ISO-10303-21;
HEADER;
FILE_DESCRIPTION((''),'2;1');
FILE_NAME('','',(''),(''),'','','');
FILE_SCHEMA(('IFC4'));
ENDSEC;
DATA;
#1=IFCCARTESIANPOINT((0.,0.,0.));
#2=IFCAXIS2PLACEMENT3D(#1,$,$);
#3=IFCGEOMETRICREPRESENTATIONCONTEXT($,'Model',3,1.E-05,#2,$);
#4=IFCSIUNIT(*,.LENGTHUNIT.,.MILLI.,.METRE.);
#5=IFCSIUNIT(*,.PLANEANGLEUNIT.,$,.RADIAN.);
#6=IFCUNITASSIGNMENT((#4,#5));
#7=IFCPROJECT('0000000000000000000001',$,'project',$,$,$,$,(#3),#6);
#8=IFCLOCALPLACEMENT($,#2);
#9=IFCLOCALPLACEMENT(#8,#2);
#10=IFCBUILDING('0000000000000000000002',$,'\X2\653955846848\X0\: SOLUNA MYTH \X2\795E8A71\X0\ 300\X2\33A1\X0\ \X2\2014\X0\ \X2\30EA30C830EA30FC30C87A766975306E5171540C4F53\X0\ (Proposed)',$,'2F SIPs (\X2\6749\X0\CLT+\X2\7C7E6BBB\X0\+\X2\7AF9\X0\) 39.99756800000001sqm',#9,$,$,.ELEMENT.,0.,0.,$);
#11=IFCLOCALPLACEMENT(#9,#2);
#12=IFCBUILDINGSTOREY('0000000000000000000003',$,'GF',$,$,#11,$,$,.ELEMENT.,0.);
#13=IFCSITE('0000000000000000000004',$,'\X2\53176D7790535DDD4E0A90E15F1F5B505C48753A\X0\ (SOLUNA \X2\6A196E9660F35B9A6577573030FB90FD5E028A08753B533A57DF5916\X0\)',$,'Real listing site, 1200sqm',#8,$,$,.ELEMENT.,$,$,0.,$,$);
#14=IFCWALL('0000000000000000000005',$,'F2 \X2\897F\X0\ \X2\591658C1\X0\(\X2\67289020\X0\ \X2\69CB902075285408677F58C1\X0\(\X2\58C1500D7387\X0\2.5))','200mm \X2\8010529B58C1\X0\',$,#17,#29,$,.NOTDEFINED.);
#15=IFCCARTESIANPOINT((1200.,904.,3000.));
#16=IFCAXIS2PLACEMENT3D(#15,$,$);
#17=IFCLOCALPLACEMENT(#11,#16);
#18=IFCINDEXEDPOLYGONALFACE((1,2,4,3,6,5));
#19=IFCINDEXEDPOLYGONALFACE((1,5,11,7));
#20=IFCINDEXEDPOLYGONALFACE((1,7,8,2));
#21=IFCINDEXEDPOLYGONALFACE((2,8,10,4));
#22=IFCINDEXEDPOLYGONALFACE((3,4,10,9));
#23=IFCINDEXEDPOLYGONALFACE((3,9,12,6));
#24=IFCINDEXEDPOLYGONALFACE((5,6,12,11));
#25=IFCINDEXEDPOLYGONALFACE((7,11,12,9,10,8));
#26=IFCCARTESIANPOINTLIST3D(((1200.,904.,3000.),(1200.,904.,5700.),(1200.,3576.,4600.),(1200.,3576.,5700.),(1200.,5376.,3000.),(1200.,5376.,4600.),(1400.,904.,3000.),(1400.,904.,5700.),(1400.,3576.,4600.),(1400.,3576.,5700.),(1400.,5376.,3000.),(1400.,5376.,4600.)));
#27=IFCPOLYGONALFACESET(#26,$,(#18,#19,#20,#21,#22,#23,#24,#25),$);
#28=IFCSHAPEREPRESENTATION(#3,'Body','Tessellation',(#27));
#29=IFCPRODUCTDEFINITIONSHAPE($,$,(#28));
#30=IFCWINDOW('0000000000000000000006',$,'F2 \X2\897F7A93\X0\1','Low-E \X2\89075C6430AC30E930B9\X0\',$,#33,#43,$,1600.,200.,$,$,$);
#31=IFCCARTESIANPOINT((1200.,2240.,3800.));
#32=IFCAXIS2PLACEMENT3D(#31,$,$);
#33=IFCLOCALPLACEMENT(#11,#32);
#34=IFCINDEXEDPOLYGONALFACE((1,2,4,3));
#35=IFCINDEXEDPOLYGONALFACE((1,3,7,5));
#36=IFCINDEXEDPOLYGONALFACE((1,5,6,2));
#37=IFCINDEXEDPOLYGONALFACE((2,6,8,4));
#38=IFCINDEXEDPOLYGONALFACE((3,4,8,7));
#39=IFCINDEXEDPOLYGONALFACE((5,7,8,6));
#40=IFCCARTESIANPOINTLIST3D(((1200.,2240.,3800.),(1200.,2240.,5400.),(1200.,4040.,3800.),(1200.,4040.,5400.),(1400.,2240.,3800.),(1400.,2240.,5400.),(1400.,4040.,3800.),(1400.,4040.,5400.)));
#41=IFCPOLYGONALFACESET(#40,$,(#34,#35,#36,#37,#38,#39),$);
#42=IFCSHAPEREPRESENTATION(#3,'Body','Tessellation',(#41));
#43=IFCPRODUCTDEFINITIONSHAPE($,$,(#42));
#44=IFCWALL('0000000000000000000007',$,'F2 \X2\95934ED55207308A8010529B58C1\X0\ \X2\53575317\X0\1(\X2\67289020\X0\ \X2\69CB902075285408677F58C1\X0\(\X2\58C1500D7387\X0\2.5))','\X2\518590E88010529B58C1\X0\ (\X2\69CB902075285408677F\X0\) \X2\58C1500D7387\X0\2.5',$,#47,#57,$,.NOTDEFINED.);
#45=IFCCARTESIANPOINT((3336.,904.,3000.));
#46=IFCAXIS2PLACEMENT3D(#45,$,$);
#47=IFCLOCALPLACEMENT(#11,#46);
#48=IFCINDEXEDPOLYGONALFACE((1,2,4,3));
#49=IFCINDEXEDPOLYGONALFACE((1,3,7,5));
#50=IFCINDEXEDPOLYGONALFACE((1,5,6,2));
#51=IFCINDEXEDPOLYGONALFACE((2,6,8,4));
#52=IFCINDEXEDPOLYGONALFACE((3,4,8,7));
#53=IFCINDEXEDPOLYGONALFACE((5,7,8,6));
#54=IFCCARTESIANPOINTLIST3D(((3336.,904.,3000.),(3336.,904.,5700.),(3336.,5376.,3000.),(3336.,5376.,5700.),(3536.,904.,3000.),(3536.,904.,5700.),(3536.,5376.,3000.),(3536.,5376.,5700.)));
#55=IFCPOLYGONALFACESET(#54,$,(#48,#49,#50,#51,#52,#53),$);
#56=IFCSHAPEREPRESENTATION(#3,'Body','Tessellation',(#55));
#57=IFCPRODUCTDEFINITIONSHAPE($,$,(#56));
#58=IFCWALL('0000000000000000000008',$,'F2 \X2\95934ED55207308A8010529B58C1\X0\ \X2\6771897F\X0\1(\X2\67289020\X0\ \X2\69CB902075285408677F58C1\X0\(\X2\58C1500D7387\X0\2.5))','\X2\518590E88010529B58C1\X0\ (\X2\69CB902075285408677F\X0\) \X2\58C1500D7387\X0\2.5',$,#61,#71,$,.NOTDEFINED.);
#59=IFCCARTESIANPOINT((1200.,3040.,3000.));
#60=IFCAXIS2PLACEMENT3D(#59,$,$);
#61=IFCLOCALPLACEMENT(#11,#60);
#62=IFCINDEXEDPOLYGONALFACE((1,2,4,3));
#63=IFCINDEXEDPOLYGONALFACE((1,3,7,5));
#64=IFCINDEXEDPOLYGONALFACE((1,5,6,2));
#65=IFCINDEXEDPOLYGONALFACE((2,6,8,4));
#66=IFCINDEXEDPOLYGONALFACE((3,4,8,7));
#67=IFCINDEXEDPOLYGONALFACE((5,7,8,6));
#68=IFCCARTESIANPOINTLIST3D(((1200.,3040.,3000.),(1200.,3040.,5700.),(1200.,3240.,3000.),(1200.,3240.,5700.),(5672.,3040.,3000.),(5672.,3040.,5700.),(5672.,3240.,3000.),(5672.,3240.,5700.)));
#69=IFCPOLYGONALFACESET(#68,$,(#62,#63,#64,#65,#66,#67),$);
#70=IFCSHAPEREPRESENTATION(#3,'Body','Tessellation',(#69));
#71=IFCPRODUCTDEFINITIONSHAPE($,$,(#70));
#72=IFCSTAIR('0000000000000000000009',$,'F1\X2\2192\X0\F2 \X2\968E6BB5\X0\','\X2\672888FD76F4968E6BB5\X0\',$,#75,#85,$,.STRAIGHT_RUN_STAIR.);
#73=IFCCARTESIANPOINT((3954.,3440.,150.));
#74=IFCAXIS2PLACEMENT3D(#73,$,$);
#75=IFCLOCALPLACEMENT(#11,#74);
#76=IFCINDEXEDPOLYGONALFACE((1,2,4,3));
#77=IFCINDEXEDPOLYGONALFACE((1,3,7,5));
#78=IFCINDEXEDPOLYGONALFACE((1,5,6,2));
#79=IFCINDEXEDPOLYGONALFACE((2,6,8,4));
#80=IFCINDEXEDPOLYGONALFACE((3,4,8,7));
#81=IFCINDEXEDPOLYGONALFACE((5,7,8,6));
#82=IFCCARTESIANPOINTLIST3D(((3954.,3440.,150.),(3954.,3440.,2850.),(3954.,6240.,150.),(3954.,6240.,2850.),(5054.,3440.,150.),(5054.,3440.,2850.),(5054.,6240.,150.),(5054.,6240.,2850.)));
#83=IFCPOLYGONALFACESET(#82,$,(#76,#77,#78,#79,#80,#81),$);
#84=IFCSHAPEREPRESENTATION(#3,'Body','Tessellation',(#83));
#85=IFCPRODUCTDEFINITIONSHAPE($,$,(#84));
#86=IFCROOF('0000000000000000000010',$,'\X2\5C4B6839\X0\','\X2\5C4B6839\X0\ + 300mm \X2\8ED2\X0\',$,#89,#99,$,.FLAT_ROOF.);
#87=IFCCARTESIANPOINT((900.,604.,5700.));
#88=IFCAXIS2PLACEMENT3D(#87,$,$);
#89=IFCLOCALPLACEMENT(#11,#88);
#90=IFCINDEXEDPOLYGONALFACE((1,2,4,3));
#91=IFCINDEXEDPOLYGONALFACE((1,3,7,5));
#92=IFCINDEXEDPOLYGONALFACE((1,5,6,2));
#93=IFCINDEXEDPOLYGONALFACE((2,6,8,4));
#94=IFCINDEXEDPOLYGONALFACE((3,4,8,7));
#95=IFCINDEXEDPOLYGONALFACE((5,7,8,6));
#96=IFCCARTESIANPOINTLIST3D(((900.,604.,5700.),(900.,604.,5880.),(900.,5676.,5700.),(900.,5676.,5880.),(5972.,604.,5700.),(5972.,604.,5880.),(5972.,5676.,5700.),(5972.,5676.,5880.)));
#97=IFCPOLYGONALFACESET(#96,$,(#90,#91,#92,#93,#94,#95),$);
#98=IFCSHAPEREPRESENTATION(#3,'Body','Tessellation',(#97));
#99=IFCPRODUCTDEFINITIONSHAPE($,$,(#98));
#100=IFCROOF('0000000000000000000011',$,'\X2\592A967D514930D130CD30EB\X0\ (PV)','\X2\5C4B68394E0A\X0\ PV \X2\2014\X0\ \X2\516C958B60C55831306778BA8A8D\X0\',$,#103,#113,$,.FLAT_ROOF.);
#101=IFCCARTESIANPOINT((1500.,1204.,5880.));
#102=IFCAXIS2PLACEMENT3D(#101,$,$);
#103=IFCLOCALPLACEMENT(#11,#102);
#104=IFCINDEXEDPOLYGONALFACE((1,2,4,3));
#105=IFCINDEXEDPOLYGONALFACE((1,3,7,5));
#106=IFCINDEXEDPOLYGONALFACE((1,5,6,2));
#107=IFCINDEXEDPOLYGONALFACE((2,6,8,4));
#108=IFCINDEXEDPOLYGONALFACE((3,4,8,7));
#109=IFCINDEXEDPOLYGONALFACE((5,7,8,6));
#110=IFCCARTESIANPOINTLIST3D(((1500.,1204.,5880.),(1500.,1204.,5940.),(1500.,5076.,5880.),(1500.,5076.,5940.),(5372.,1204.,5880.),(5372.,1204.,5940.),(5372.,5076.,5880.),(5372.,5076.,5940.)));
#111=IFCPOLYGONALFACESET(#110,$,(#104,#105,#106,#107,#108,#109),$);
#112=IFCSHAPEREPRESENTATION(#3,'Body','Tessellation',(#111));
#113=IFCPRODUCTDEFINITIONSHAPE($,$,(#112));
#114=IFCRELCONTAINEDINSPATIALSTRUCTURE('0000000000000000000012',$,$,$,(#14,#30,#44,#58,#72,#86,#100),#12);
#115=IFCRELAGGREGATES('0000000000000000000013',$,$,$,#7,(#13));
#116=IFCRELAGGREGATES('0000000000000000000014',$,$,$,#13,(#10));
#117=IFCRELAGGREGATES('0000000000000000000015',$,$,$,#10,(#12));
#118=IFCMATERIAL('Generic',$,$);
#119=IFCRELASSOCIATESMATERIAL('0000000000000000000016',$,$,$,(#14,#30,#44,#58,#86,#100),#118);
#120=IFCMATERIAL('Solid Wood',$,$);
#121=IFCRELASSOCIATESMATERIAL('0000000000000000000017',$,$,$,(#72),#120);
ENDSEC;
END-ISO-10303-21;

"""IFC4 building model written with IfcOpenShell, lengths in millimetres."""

from ifc_helpers import new_model, si_unit, frame, frame_2d, origin, place, context, project, spatial, rectangle, extrude, material, element, fill, save


model = new_model("IFC4")

# Units and contexts
model_context = context("Model", 3, precision=1e-05, world=origin())
ifc_project = project(units=[si_unit("LENGTHUNIT", "METRE", prefix="MILLI"), si_unit("PLANEANGLEUNIT", "RADIAN")], contexts=[model_context])

# Site, building, storey
site_placement = place(None, origin())
site = spatial("IfcSite", under=ifc_project, at=site_placement, Name="北海道川上郡弟子屈町 (SOLUNA 標準想定敷地・都市計画区域外)", ObjectType="Real listing site, 1200sqm", CompositionType="ELEMENT", RefElevation=0.0)
building_placement = place(site_placement, origin())
building = spatial("IfcBuilding", under=site, at=building_placement, Name="改善案: SOLUNA MYTH 神話 300㎡ — リトリート究極の共同体 (Proposed)", ObjectType="2F SIPs (杉CLT+籾殻+竹) 39.99756800000001sqm", CompositionType="ELEMENT", ElevationOfRefHeight=0.0, ElevationOfTerrain=0.0)
storey_placement = place(building_placement, origin())
storey = spatial("IfcBuildingStorey", under=building, at=storey_placement, Name="GF", CompositionType="ELEMENT", Elevation=0.0)

# Shared definitions
ifc_material_1 = material(Name="Generic")

# Shared definitions
ifc_material_2 = material(Name="Solid Wood")

# Wall, opening, window
wall_1_placement = place(storey_placement, frame((1200.0, 904.0, 3000.0)))
wall_1 = element("IfcWall", 1, at=wall_1_placement, inside=storey, material=ifc_material_1, Name="F2 西 外壁(木造 構造用合板壁(壁倍率2.5))", Description="200mm 耐力壁", PredefinedType="NOTDEFINED", context=model_context, shape_type="SweptSolid", body=[
    extrude(rectangle(XDim=200.0, YDim=4472.0, at=frame_2d((100.0, 2236.0))), frame((1200.0, 904.0, 3000.0)), (0.0, 0.0, 1.0), 2700.0),
])
opening_1_placement = place(storey_placement, frame((1200.0, 2240.0, 3800.0)))
opening_1 = element("IfcOpeningElement", 2, at=opening_1_placement, cuts=wall_1, PredefinedType="NOTDEFINED", context=model_context, shape_type="SweptSolid", body=[
    extrude(rectangle(XDim=200.0, YDim=1800.0, at=frame_2d((100.0, 900.0))), frame((1200.0, 2240.0, 3800.0)), (0.0, 0.0, 1.0), 1600.0),
])
window_1_placement = place(storey_placement, frame((1200.0, 2240.0, 3800.0)))
window_1 = element("IfcWindow", 3, at=window_1_placement, inside=storey, material=ifc_material_1, Name="F2 西窓1", Description="Low-E 複層ガラス", OverallHeight=1600.0, OverallWidth=200.0, context=model_context, shape_type="SweptSolid", body=[
    extrude(rectangle(XDim=200.0, YDim=1800.0, at=frame_2d((100.0, 900.0))), frame((1200.0, 2240.0, 3800.0)), (0.0, 0.0, 1.0), 1600.0),
])
fill(opening_1, window_1)

# Walls
wall_2_placement = place(storey_placement, frame((3336.0, 904.0, 3000.0)))
element("IfcWall", 4, at=wall_2_placement, inside=storey, material=ifc_material_1, Name="F2 間仕切り耐力壁 南北1(木造 構造用合板壁(壁倍率2.5))", Description="内部耐力壁 (構造用合板) 壁倍率2.5", PredefinedType="NOTDEFINED", context=model_context, shape_type="SweptSolid", body=[
    extrude(rectangle(XDim=200.0, YDim=4472.0, at=frame_2d((100.0, 2236.0))), frame((3336.0, 904.0, 3000.0)), (0.0, 0.0, 1.0), 2700.0),
])
wall_3_placement = place(storey_placement, frame((1200.0, 3040.0, 3000.0)))
element("IfcWall", 5, at=wall_3_placement, inside=storey, material=ifc_material_1, Name="F2 間仕切り耐力壁 東西1(木造 構造用合板壁(壁倍率2.5))", Description="内部耐力壁 (構造用合板) 壁倍率2.5", PredefinedType="NOTDEFINED", context=model_context, shape_type="SweptSolid", body=[
    extrude(rectangle(XDim=4472.0, YDim=200.0, at=frame_2d((2236.0, 100.0))), frame((1200.0, 3040.0, 3000.0)), (0.0, 0.0, 1.0), 2700.0),
])

# Stair
stair_placement = place(storey_placement, frame((3954.0, 3440.0, 150.0)))
element("IfcStair", 6, at=stair_placement, inside=storey, material=ifc_material_2, Name="F1→F2 階段", Description="木製直階段", PredefinedType="STRAIGHT_RUN_STAIR", context=model_context, shape_type="SweptSolid", body=[
    extrude(rectangle(XDim=1100.0, YDim=2800.0, at=frame_2d((550.0, 1400.0))), frame((3954.0, 3440.0, 150.0)), (0.0, 0.0, 1.0), 2700.0),
])

# Roofs
roof_1_placement = place(storey_placement, frame((900.0, 604.0, 5700.0)))
element("IfcRoof", 7, at=roof_1_placement, inside=storey, material=ifc_material_1, Name="屋根", Description="屋根 + 300mm 軒", PredefinedType="FLAT_ROOF", context=model_context, shape_type="SweptSolid", body=[
    extrude(rectangle(XDim=5072.0, YDim=5072.0, at=frame_2d((2536.0, 2536.0))), frame((900.0, 604.0, 5700.0)), (0.0, 0.0, 1.0), 180.0),
])
roof_2_placement = place(storey_placement, frame((1500.0, 1204.0, 5880.0)))
element("IfcRoof", 8, at=roof_2_placement, inside=storey, material=ifc_material_1, Name="太陽光パネル (PV)", Description="屋根上 PV — 公開情報で確認", PredefinedType="FLAT_ROOF", context=model_context, shape_type="SweptSolid", body=[
    extrude(rectangle(XDim=3872.0, YDim=3872.0, at=frame_2d((1936.0, 1936.0))), frame((1500.0, 1204.0, 5880.0)), (0.0, 0.0, 1.0), 60.0),
])

save(model, "model.ifc")
